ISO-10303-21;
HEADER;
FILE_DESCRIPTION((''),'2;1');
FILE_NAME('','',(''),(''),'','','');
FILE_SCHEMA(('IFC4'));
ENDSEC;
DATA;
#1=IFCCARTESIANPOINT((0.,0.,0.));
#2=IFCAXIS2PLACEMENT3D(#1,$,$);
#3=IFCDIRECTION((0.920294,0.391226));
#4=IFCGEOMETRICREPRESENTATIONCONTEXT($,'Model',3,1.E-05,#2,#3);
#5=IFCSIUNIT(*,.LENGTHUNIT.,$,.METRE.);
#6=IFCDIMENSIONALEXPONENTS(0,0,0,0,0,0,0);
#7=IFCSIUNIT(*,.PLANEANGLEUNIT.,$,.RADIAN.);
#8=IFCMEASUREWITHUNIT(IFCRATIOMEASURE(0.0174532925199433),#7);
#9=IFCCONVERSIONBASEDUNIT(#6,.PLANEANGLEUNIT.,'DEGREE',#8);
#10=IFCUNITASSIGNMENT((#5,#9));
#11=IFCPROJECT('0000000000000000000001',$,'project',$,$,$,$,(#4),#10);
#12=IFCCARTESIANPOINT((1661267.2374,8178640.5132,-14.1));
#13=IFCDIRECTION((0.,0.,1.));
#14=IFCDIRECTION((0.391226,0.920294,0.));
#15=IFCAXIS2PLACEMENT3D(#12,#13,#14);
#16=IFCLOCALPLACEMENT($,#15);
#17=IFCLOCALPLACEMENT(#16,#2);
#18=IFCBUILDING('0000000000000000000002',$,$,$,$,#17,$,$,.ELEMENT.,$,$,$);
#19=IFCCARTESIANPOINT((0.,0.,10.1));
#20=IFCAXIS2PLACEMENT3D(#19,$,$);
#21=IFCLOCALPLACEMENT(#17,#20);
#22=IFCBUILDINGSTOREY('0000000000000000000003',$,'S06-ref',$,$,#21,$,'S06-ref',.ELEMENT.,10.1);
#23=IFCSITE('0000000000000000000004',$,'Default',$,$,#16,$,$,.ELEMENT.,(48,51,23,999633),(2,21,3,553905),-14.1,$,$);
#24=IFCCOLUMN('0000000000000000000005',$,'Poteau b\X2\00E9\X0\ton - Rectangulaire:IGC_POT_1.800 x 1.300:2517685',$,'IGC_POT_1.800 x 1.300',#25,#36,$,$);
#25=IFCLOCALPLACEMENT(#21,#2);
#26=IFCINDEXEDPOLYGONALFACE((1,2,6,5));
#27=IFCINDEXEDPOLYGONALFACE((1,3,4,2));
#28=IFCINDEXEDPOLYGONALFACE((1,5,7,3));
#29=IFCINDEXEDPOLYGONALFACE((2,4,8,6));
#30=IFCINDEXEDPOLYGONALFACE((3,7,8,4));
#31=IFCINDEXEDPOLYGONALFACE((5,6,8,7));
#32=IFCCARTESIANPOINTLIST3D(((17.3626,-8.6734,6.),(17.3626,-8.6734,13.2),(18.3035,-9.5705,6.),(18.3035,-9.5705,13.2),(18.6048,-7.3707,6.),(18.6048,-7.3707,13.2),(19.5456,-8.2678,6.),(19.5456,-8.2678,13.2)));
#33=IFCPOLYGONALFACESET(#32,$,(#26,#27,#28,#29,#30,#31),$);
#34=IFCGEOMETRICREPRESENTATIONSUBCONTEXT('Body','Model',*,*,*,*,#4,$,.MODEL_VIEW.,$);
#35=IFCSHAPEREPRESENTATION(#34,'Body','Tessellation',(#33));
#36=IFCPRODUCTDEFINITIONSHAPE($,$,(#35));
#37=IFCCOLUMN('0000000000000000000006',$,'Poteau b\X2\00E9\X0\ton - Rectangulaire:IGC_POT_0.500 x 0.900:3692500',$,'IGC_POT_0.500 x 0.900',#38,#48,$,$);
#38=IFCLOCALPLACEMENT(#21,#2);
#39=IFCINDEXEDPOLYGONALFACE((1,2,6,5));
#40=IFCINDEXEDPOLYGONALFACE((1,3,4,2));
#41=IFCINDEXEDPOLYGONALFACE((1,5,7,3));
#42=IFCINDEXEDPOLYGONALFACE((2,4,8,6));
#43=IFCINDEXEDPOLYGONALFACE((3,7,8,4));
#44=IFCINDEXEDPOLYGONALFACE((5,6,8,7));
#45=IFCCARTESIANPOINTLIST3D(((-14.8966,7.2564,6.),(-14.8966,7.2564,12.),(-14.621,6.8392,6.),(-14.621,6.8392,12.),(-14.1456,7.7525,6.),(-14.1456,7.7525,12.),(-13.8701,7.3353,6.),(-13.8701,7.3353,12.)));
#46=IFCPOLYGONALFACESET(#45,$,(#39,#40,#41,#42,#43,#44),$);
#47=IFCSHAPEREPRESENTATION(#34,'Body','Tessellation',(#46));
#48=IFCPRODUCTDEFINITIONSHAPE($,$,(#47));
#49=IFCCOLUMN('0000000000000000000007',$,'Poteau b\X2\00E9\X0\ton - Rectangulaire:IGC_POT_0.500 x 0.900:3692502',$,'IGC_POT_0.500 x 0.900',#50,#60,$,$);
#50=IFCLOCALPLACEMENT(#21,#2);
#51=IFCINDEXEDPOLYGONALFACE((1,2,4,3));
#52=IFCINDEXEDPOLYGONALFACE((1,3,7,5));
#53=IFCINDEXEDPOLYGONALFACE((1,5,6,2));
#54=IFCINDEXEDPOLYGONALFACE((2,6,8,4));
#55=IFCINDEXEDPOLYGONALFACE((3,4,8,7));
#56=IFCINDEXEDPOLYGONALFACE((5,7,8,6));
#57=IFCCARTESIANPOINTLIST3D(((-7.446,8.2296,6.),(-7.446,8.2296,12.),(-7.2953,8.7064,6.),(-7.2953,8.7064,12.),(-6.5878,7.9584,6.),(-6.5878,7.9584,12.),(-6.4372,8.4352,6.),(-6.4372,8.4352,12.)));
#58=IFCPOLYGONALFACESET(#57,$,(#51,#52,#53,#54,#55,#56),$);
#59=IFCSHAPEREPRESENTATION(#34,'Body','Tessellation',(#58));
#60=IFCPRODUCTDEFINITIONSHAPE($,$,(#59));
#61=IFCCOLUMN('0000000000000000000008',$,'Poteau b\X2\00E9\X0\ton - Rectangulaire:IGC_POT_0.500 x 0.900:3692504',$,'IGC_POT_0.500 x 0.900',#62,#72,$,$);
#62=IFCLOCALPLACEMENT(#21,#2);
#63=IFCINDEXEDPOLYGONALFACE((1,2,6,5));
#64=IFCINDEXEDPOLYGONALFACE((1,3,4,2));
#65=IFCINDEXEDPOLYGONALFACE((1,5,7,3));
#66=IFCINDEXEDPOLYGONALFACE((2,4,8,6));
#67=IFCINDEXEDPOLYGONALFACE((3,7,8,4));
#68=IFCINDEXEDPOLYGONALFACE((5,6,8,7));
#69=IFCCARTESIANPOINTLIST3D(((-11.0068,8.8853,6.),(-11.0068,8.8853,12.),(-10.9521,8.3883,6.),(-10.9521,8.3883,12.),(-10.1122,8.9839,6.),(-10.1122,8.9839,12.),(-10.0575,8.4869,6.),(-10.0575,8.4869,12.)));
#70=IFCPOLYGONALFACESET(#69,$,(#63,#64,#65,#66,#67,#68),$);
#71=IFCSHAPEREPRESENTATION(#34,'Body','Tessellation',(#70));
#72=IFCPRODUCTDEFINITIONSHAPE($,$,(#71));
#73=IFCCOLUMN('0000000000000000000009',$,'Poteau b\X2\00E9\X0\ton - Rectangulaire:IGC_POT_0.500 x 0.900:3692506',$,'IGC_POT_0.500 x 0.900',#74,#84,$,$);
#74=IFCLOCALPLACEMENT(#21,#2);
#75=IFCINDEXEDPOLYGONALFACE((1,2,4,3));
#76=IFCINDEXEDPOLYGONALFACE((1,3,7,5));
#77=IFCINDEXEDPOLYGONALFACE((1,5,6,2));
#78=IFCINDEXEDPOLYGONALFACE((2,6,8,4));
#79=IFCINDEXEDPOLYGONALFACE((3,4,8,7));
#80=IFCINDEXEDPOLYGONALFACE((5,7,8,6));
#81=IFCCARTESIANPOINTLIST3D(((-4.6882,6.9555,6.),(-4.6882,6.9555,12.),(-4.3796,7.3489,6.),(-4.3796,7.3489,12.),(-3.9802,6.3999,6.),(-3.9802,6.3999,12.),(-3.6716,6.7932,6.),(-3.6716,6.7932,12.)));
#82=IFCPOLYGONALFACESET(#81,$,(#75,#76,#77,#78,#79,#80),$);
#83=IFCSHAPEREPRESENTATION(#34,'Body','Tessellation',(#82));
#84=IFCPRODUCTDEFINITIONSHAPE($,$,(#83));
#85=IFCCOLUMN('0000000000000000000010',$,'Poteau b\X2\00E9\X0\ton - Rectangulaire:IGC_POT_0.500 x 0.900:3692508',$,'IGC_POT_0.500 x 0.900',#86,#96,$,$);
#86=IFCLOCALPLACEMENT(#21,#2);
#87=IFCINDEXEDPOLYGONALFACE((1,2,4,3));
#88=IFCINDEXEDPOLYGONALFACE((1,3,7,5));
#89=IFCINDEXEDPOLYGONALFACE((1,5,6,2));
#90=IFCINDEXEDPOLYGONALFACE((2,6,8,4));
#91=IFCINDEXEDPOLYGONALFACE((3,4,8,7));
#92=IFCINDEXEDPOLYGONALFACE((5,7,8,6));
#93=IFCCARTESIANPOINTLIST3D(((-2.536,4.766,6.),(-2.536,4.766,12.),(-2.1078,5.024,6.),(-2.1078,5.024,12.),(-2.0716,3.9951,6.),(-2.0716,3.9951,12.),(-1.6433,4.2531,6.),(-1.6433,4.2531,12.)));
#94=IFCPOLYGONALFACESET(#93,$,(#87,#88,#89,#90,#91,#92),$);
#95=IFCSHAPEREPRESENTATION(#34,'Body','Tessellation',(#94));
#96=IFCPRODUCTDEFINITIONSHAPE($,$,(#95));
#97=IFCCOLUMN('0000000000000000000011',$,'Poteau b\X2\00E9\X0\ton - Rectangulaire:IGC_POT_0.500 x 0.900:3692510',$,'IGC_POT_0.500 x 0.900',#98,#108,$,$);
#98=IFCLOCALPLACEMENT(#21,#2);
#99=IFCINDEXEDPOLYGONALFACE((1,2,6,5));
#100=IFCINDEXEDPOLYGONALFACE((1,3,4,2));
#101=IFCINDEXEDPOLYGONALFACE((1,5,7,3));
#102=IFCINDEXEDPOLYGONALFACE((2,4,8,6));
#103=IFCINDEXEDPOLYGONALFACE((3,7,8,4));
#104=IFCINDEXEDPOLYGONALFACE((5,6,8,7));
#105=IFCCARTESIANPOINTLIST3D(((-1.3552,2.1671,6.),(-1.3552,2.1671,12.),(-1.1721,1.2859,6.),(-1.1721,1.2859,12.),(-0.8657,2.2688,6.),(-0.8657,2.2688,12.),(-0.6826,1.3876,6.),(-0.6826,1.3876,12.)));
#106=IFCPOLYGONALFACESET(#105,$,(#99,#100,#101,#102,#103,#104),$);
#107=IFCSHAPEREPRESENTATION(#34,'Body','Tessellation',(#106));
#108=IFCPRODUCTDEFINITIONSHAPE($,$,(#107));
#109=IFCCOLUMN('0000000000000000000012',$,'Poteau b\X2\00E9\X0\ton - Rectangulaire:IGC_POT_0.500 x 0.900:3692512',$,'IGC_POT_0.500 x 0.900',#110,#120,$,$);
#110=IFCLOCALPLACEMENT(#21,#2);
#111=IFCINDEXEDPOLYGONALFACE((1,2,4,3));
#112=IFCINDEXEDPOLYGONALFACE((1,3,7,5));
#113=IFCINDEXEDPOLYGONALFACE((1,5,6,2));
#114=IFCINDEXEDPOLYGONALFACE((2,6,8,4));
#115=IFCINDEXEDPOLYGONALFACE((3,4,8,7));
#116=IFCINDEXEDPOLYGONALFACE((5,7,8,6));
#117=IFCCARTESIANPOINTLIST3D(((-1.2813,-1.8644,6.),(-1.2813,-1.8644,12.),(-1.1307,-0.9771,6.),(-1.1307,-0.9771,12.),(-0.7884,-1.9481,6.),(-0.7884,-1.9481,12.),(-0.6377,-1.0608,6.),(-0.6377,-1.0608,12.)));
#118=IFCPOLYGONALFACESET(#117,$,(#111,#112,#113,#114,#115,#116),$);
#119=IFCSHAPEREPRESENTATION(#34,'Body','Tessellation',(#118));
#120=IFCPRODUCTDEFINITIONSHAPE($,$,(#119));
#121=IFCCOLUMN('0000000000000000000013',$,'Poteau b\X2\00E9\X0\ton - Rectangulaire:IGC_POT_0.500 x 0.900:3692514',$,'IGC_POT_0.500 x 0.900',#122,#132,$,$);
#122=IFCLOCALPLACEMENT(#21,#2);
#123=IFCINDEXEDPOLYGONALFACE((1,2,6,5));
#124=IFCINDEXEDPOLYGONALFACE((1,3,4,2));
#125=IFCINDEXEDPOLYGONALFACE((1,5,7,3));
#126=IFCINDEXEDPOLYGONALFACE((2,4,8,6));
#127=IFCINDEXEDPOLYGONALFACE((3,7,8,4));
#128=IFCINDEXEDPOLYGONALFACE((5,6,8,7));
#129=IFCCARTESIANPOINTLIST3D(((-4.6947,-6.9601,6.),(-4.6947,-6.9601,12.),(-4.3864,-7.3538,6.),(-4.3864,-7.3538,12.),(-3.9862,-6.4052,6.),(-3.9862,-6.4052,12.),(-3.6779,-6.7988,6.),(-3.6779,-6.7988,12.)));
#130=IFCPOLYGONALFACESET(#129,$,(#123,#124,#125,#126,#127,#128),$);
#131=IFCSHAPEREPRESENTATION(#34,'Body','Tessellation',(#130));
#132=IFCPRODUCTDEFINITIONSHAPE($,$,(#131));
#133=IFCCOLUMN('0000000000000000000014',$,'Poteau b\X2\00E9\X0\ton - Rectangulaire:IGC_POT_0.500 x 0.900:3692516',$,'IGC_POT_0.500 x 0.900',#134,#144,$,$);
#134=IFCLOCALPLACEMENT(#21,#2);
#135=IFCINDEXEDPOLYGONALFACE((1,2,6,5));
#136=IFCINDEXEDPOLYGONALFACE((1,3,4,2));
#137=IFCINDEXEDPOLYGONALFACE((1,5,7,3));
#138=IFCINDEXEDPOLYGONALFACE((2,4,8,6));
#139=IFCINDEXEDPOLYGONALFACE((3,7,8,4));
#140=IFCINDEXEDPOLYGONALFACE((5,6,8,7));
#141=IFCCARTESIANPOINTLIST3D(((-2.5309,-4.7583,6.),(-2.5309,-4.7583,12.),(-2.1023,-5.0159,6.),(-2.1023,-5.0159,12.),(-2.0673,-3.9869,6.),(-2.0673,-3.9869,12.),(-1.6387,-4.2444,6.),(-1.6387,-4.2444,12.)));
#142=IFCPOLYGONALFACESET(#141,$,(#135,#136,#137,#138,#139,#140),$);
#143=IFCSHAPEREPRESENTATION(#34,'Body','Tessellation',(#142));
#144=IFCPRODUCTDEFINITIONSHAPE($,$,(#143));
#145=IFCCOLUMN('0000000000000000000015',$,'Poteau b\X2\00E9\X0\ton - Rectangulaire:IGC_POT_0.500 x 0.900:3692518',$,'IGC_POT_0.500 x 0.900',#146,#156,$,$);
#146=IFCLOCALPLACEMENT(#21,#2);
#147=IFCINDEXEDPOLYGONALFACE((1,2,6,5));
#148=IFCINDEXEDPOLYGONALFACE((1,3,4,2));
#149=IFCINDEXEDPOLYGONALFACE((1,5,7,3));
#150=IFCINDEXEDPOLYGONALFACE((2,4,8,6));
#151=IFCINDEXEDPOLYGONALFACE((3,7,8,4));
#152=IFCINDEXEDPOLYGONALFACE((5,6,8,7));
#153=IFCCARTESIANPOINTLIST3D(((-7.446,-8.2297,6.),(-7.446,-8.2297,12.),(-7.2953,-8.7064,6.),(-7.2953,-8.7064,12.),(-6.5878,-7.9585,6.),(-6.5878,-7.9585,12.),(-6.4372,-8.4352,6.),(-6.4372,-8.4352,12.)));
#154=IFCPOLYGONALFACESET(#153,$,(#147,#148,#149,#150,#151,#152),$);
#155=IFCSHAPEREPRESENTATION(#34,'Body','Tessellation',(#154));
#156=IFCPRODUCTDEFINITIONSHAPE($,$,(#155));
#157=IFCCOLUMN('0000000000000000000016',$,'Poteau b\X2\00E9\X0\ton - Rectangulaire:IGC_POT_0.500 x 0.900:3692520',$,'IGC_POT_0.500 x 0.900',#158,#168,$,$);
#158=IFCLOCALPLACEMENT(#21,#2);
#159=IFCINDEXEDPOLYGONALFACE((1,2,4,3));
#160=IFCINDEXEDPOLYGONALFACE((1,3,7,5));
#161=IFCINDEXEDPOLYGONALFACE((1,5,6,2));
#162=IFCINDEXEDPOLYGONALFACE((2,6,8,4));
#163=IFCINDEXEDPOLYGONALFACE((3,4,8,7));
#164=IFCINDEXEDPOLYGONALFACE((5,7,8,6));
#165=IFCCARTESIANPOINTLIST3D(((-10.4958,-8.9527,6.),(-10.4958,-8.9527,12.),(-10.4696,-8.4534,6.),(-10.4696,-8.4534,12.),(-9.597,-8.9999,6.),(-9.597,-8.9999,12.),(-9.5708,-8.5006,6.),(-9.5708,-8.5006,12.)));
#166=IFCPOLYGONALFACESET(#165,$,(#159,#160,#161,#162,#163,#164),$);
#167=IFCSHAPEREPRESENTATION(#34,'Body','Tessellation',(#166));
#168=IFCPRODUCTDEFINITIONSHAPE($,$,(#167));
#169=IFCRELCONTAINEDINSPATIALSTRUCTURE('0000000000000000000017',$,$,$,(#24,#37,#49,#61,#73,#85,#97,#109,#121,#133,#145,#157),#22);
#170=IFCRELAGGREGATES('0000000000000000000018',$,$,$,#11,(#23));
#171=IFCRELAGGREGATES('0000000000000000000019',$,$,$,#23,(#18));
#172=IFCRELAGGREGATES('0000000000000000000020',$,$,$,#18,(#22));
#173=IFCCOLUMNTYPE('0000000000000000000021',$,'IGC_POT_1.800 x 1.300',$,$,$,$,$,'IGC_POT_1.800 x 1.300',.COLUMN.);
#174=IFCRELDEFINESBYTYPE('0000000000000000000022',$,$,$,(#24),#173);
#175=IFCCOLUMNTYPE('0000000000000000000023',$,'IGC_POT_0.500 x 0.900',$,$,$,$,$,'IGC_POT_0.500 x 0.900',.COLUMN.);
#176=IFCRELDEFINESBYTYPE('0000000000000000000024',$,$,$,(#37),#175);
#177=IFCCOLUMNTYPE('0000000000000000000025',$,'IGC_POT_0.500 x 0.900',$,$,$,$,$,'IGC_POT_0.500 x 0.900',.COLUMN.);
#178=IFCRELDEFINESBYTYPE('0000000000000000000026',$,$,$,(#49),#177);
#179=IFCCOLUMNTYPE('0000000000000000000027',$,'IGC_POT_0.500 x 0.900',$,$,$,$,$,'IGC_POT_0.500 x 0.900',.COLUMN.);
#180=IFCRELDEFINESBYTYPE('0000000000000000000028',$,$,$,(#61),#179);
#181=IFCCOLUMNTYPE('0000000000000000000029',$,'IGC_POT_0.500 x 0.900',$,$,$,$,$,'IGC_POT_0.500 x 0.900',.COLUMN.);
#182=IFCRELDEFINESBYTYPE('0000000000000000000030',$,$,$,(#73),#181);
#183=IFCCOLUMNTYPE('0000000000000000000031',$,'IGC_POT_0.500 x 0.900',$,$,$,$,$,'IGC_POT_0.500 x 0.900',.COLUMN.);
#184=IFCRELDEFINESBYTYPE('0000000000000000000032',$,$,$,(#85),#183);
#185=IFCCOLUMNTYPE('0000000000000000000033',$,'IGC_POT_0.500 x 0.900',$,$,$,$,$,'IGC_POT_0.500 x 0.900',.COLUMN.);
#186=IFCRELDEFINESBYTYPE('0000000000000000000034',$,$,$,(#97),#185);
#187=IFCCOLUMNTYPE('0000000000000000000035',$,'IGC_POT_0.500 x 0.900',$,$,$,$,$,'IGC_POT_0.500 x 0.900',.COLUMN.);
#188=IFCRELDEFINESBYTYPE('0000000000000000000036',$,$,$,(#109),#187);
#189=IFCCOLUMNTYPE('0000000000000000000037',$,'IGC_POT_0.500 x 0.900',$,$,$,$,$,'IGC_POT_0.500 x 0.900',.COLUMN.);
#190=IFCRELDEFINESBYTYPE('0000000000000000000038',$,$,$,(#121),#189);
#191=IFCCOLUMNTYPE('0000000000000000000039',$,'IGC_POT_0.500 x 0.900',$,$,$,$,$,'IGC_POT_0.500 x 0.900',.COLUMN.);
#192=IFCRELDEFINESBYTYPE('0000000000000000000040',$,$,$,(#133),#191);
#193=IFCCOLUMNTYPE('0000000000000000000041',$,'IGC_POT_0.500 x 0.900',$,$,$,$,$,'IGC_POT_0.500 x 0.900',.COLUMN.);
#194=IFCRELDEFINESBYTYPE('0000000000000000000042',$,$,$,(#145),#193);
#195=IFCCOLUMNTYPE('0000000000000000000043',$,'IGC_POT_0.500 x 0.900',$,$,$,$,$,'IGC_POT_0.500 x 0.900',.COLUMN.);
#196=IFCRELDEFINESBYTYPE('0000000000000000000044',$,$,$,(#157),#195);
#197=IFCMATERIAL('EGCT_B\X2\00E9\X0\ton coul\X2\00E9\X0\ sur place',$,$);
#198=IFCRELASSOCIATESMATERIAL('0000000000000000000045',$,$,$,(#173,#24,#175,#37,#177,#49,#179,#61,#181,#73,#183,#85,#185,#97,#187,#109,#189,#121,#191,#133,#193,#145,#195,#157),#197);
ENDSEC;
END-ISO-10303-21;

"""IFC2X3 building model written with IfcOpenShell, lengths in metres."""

from ifc_helpers import new_model, entity, si_unit, converted_unit, direction, frame, frame_2d, origin, origin_2d_with_axis, place, context, subcontext, project, spatial, rectangle, extrude, source, transform, mapped, material, type_object, type_shapes, element, save


model = new_model("IFC2X3")

# Units and contexts
model_context = context("Model", 3, precision=1e-05, world=origin(), true_north=direction((0.920294, 0.391226)))
body_context = subcontext(model_context, "Body", "Model", "MODEL_VIEW")
ifc_project = project(units=[si_unit("LENGTHUNIT", "METRE"), converted_unit("PLANEANGLEUNIT", "DEGREE", entity("IfcRatioMeasure", 0.0174532925199433), si_unit("PLANEANGLEUNIT", "RADIAN"), dimensions=[0, 0, 0, 0, 0, 0, 0])], contexts=[model_context])

# Site, building, storey
site_placement = place(None, frame((1661267.2374, 8178640.5132, -14.1), z_axis=(0.0, 0.0, 1.0), x_axis=(0.391226, 0.920294, 0.0)))
site = spatial("IfcSite", under=ifc_project, at=site_placement, Name="Default", CompositionType="ELEMENT", RefLatitude=(48, 51, 23, 999633), RefLongitude=(2, 21, 3, 553905), RefElevation=-14.1)
building_placement = place(site_placement, origin())
building = spatial("IfcBuilding", under=site, at=building_placement, CompositionType="ELEMENT")
storey_placement = place(building_placement, frame((0.0, 0.0, 10.1)))
storey = spatial("IfcBuildingStorey", under=building, at=storey_placement, Name="S06-ref", LongName="S06-ref", CompositionType="ELEMENT", Elevation=10.1)

# Columns
ifc_material_1 = material(Name="EGCT_Béton coulé sur place")
column_type_1 = type_object("IfcColumnType", Name="IGC_POT_1.800 x 1.300", ElementType="IGC_POT_1.800 x 1.300", PredefinedType="COLUMN", material=ifc_material_1)
shared_shape_1 = source(origin(), body_context, "Body", "SweptSolid", [
    extrude(rectangle(XDim=1.3, YDim=1.8, at=frame_2d((0.0, 0.0), x_axis=(1.0, 0.0))), frame((18.4541, -8.4706, 16.1), z_axis=(0.0, 0.0, 1.0), x_axis=(-0.723727, 0.690086, 0.0)), (0.0, 0.0, 1.0), 7.2),
])
type_shapes(column_type_1, [shared_shape_1])
column_1_placement = place(storey_placement, frame((0.0, 0.0, -10.1)))
element("IfcColumn", 1, at=column_1_placement, inside=storey, type_object=column_type_1, material=ifc_material_1, Name="Poteau béton - Rectangulaire:IGC_POT_1.800 x 1.300:2517685", ObjectType="IGC_POT_1.800 x 1.300", context=body_context, shape_type="MappedRepresentation", body=[
    mapped(shared_shape_1, transform((0.0, 0.0, 0.0), scale=1.0)),
])
column_type_2 = type_object("IfcColumnType", Name="IGC_POT_0.500 x 0.900", ElementType="IGC_POT_0.500 x 0.900", PredefinedType="COLUMN", material=ifc_material_1)
shared_shape_2 = source(origin(), body_context, "Body", "SweptSolid", [
    extrude(rectangle(XDim=0.5, YDim=0.9, at=origin_2d_with_axis()), frame((-14.3833, 7.2959, 16.1), z_axis=(0.0, 0.0, 1.0), x_axis=(-0.551164, 0.834397, 0.0)), (0.0, 0.0, 1.0), 6.0),
])
type_shapes(column_type_2, [shared_shape_2])
column_2_placement = place(storey_placement, frame((0.0, 0.0, -10.1)))
element("IfcColumn", 2, at=column_2_placement, inside=storey, type_object=column_type_2, material=ifc_material_1, Name="Poteau béton - Rectangulaire:IGC_POT_0.500 x 0.900:3692500", ObjectType="IGC_POT_0.500 x 0.900", context=body_context, shape_type="MappedRepresentation", body=[
    mapped(shared_shape_2, transform((0.0, 0.0, 0.0), scale=1.0)),
])
column_type_3 = type_object("IfcColumnType", Name="IGC_POT_0.500 x 0.900", ElementType="IGC_POT_0.500 x 0.900", PredefinedType="COLUMN", material=ifc_material_1)
shared_shape_3 = source(origin(), body_context, "Body", "SweptSolid", [
    extrude(rectangle(XDim=0.9, YDim=0.5, at=origin_2d_with_axis()), frame((-6.9416, 8.3324, 16.1), z_axis=(0.0, 0.0, 1.0), x_axis=(-0.953513, 0.301352, 0.0)), (0.0, 0.0, 1.0), 6.0),
])
type_shapes(column_type_3, [shared_shape_3])
column_3_placement = place(storey_placement, frame((0.0, 0.0, -10.1)))
element("IfcColumn", 3, at=column_3_placement, inside=storey, type_object=column_type_3, material=ifc_material_1, Name="Poteau béton - Rectangulaire:IGC_POT_0.500 x 0.900:3692502", ObjectType="IGC_POT_0.500 x 0.900", context=body_context, shape_type="MappedRepresentation", body=[
    mapped(shared_shape_3, transform((0.0, 0.0, 0.0), scale=1.0)),
])
column_type_4 = type_object("IfcColumnType", Name="IGC_POT_0.500 x 0.900", ElementType="IGC_POT_0.500 x 0.900", PredefinedType="COLUMN", material=ifc_material_1)
shared_shape_4 = source(origin(), body_context, "Body", "SweptSolid", [
    extrude(rectangle(XDim=0.9, YDim=0.5, at=frame_2d((0.0, 0.0), x_axis=(1.0, 0.0))), frame((-10.5321, 8.6861, 16.1), z_axis=(0.0, 0.0, 1.0), x_axis=(-0.993983, -0.10953, 0.0)), (0.0, 0.0, 1.0), 6.0),
])
type_shapes(column_type_4, [shared_shape_4])
column_4_placement = place(storey_placement, frame((0.0, 0.0, -10.1)))
element("IfcColumn", 4, at=column_4_placement, inside=storey, type_object=column_type_4, material=ifc_material_1, Name="Poteau béton - Rectangulaire:IGC_POT_0.500 x 0.900:3692504", ObjectType="IGC_POT_0.500 x 0.900", context=body_context, shape_type="MappedRepresentation", body=[
    mapped(shared_shape_4, transform((0.0, 0.0, 0.0), scale=1.0)),
])
column_type_5 = type_object("IfcColumnType", Name="IGC_POT_0.500 x 0.900", ElementType="IGC_POT_0.500 x 0.900", PredefinedType="COLUMN", material=ifc_material_1)
shared_shape_5 = source(origin(), body_context, "Body", "SweptSolid", [
    extrude(rectangle(XDim=0.9, YDim=0.5, at=frame_2d((0.0, 0.0), x_axis=(1.0, 0.0))), frame((-4.1799, 6.8744, 16.1), z_axis=(0.0, 0.0, 1.0), x_axis=(-0.786665, 0.617381, 0.0)), (0.0, 0.0, 1.0), 6.0),
])
type_shapes(column_type_5, [shared_shape_5])
column_5_placement = place(storey_placement, frame((0.0, 0.0, -10.1)))
element("IfcColumn", 5, at=column_5_placement, inside=storey, type_object=column_type_5, material=ifc_material_1, Name="Poteau béton - Rectangulaire:IGC_POT_0.500 x 0.900:3692506", ObjectType="IGC_POT_0.500 x 0.900", context=body_context, shape_type="MappedRepresentation", body=[
    mapped(shared_shape_5, transform((0.0, 0.0, 0.0), scale=1.0)),
])
column_type_6 = type_object("IfcColumnType", Name="IGC_POT_0.500 x 0.900", ElementType="IGC_POT_0.500 x 0.900", PredefinedType="COLUMN", material=ifc_material_1)
shared_shape_6 = source(origin(), body_context, "Body", "SweptSolid", [
    extrude(rectangle(XDim=0.9, YDim=0.5, at=origin_2d_with_axis()), frame((-2.0897, 4.5096, 16.1), z_axis=(0.0, 0.0, 1.0), x_axis=(-0.516043, 0.856562, 0.0)), (0.0, 0.0, 1.0), 6.0),
])
type_shapes(column_type_6, [shared_shape_6])
column_6_placement = place(storey_placement, frame((0.0, 0.0, -10.1)))
element("IfcColumn", 6, at=column_6_placement, inside=storey, type_object=column_type_6, material=ifc_material_1, Name="Poteau béton - Rectangulaire:IGC_POT_0.500 x 0.900:3692508", ObjectType="IGC_POT_0.500 x 0.900", context=body_context, shape_type="MappedRepresentation", body=[
    mapped(shared_shape_6, transform((0.0, 0.0, 0.0), scale=1.0)),
])
column_type_7 = type_object("IfcColumnType", Name="IGC_POT_0.500 x 0.900", ElementType="IGC_POT_0.500 x 0.900", PredefinedType="COLUMN", material=ifc_material_1)
shared_shape_7 = source(origin(), body_context, "Body", "SweptSolid", [
    extrude(rectangle(XDim=0.9, YDim=0.5, at=origin_2d_with_axis()), frame((-1.0189, 1.7774, 16.1), z_axis=(0.0, 0.0, 1.0), x_axis=(-0.203394, 0.979097, 0.0)), (0.0, 0.0, 1.0), 6.0),
])
type_shapes(column_type_7, [shared_shape_7])
column_7_placement = place(storey_placement, frame((0.0, 0.0, -10.1)))
element("IfcColumn", 7, at=column_7_placement, inside=storey, type_object=column_type_7, material=ifc_material_1, Name="Poteau béton - Rectangulaire:IGC_POT_0.500 x 0.900:3692510", ObjectType="IGC_POT_0.500 x 0.900", context=body_context, shape_type="MappedRepresentation", body=[
    mapped(shared_shape_7, transform((0.0, 0.0, 0.0), scale=1.0)),
])
column_type_8 = type_object("IfcColumnType", Name="IGC_POT_0.500 x 0.900", ElementType="IGC_POT_0.500 x 0.900", PredefinedType="COLUMN", material=ifc_material_1)
shared_shape_8 = source(origin(), body_context, "Body", "SweptSolid", [
    extrude(rectangle(XDim=0.9, YDim=0.5, at=frame_2d((0.0, 0.0), x_axis=(1.0, 0.0))), frame((-0.9595, -1.4626, 16.1), z_axis=(0.0, 0.0, 1.0), x_axis=(0.167362, 0.985895, 0.0)), (0.0, 0.0, 1.0), 6.0),
])
type_shapes(column_type_8, [shared_shape_8])
column_8_placement = place(storey_placement, frame((0.0, 0.0, -10.1)))
element("IfcColumn", 8, at=column_8_placement, inside=storey, type_object=column_type_8, material=ifc_material_1, Name="Poteau béton - Rectangulaire:IGC_POT_0.500 x 0.900:3692512", ObjectType="IGC_POT_0.500 x 0.900", context=body_context, shape_type="MappedRepresentation", body=[
    mapped(shared_shape_8, transform((0.0, 0.0, 0.0), scale=1.0)),
])
column_type_9 = type_object("IfcColumnType", Name="IGC_POT_0.500 x 0.900", ElementType="IGC_POT_0.500 x 0.900", PredefinedType="COLUMN", material=ifc_material_1)
shared_shape_9 = source(origin(), body_context, "Body", "SweptSolid", [
    extrude(rectangle(XDim=0.9, YDim=0.5, at=origin_2d_with_axis()), frame((-4.1863, -6.8795, 16.1), z_axis=(0.0, 0.0, 1.0), x_axis=(0.787239, 0.616648, 0.0)), (0.0, 0.0, 1.0), 6.0),
])
type_shapes(column_type_9, [shared_shape_9])
column_9_placement = place(storey_placement, frame((0.0, 0.0, -10.1)))
element("IfcColumn", 9, at=column_9_placement, inside=storey, type_object=column_type_9, material=ifc_material_1, Name="Poteau béton - Rectangulaire:IGC_POT_0.500 x 0.900:3692514", ObjectType="IGC_POT_0.500 x 0.900", context=body_context, shape_type="MappedRepresentation", body=[
    mapped(shared_shape_9, transform((0.0, 0.0, 0.0), scale=1.0)),
])
column_type_10 = type_object("IfcColumnType", Name="IGC_POT_0.500 x 0.900", ElementType="IGC_POT_0.500 x 0.900", PredefinedType="COLUMN", material=ifc_material_1)
shared_shape_10 = source(origin(), body_context, "Body", "SweptSolid", [
    extrude(rectangle(XDim=0.9, YDim=0.5, at=frame_2d((0.0, 0.0), x_axis=(1.0, 0.0))), frame((-2.0848, -4.5014, 16.1), z_axis=(0.0, 0.0, 1.0), x_axis=(0.515106, 0.857126, 0.0)), (0.0, 0.0, 1.0), 6.0),
])
type_shapes(column_type_10, [shared_shape_10])
column_10_placement = place(storey_placement, frame((0.0, 0.0, -10.1)))
element("IfcColumn", 10, at=column_10_placement, inside=storey, type_object=column_type_10, material=ifc_material_1, Name="Poteau béton - Rectangulaire:IGC_POT_0.500 x 0.900:3692516", ObjectType="IGC_POT_0.500 x 0.900", context=body_context, shape_type="MappedRepresentation", body=[
    mapped(shared_shape_10, transform((0.0, 0.0, 0.0), scale=1.0)),
])
column_type_11 = type_object("IfcColumnType", Name="IGC_POT_0.500 x 0.900", ElementType="IGC_POT_0.500 x 0.900", PredefinedType="COLUMN", material=ifc_material_1)
shared_shape_11 = source(origin(), body_context, "Body", "SweptSolid", [
    extrude(rectangle(XDim=0.5, YDim=0.9, at=origin_2d_with_axis()), frame((-6.9416, -8.3325, 16.1), z_axis=(0.0, 0.0, 1.0), x_axis=(-0.301353, 0.953513, 0.0)), (0.0, 0.0, 1.0), 6.0),
])
type_shapes(column_type_11, [shared_shape_11])
column_11_placement = place(storey_placement, frame((0.0, 0.0, -10.1)))
element("IfcColumn", 11, at=column_11_placement, inside=storey, type_object=column_type_11, material=ifc_material_1, Name="Poteau béton - Rectangulaire:IGC_POT_0.500 x 0.900:3692518", ObjectType="IGC_POT_0.500 x 0.900", context=body_context, shape_type="MappedRepresentation", body=[
    mapped(shared_shape_11, transform((0.0, 0.0, 0.0), scale=1.0)),
])
column_type_12 = type_object("IfcColumnType", Name="IGC_POT_0.500 x 0.900", ElementType="IGC_POT_0.500 x 0.900", PredefinedType="COLUMN", material=ifc_material_1)
shared_shape_12 = source(origin(), body_context, "Body", "SweptSolid", [
    extrude(rectangle(XDim=0.5, YDim=0.9, at=frame_2d((0.0, 0.0), x_axis=(1.0, 0.0))), frame((-10.0333, -8.7267, 16.1), z_axis=(0.0, 0.0, 1.0), x_axis=(0.052447, 0.998624, 0.0)), (0.0, 0.0, 1.0), 6.0),
])
type_shapes(column_type_12, [shared_shape_12])
column_12_placement = place(storey_placement, frame((0.0, 0.0, -10.1)))
element("IfcColumn", 12, at=column_12_placement, inside=storey, type_object=column_type_12, material=ifc_material_1, Name="Poteau béton - Rectangulaire:IGC_POT_0.500 x 0.900:3692520", ObjectType="IGC_POT_0.500 x 0.900", context=body_context, shape_type="MappedRepresentation", body=[
    mapped(shared_shape_12, transform((0.0, 0.0, 0.0), scale=1.0)),
])

save(model, "model.ifc")
